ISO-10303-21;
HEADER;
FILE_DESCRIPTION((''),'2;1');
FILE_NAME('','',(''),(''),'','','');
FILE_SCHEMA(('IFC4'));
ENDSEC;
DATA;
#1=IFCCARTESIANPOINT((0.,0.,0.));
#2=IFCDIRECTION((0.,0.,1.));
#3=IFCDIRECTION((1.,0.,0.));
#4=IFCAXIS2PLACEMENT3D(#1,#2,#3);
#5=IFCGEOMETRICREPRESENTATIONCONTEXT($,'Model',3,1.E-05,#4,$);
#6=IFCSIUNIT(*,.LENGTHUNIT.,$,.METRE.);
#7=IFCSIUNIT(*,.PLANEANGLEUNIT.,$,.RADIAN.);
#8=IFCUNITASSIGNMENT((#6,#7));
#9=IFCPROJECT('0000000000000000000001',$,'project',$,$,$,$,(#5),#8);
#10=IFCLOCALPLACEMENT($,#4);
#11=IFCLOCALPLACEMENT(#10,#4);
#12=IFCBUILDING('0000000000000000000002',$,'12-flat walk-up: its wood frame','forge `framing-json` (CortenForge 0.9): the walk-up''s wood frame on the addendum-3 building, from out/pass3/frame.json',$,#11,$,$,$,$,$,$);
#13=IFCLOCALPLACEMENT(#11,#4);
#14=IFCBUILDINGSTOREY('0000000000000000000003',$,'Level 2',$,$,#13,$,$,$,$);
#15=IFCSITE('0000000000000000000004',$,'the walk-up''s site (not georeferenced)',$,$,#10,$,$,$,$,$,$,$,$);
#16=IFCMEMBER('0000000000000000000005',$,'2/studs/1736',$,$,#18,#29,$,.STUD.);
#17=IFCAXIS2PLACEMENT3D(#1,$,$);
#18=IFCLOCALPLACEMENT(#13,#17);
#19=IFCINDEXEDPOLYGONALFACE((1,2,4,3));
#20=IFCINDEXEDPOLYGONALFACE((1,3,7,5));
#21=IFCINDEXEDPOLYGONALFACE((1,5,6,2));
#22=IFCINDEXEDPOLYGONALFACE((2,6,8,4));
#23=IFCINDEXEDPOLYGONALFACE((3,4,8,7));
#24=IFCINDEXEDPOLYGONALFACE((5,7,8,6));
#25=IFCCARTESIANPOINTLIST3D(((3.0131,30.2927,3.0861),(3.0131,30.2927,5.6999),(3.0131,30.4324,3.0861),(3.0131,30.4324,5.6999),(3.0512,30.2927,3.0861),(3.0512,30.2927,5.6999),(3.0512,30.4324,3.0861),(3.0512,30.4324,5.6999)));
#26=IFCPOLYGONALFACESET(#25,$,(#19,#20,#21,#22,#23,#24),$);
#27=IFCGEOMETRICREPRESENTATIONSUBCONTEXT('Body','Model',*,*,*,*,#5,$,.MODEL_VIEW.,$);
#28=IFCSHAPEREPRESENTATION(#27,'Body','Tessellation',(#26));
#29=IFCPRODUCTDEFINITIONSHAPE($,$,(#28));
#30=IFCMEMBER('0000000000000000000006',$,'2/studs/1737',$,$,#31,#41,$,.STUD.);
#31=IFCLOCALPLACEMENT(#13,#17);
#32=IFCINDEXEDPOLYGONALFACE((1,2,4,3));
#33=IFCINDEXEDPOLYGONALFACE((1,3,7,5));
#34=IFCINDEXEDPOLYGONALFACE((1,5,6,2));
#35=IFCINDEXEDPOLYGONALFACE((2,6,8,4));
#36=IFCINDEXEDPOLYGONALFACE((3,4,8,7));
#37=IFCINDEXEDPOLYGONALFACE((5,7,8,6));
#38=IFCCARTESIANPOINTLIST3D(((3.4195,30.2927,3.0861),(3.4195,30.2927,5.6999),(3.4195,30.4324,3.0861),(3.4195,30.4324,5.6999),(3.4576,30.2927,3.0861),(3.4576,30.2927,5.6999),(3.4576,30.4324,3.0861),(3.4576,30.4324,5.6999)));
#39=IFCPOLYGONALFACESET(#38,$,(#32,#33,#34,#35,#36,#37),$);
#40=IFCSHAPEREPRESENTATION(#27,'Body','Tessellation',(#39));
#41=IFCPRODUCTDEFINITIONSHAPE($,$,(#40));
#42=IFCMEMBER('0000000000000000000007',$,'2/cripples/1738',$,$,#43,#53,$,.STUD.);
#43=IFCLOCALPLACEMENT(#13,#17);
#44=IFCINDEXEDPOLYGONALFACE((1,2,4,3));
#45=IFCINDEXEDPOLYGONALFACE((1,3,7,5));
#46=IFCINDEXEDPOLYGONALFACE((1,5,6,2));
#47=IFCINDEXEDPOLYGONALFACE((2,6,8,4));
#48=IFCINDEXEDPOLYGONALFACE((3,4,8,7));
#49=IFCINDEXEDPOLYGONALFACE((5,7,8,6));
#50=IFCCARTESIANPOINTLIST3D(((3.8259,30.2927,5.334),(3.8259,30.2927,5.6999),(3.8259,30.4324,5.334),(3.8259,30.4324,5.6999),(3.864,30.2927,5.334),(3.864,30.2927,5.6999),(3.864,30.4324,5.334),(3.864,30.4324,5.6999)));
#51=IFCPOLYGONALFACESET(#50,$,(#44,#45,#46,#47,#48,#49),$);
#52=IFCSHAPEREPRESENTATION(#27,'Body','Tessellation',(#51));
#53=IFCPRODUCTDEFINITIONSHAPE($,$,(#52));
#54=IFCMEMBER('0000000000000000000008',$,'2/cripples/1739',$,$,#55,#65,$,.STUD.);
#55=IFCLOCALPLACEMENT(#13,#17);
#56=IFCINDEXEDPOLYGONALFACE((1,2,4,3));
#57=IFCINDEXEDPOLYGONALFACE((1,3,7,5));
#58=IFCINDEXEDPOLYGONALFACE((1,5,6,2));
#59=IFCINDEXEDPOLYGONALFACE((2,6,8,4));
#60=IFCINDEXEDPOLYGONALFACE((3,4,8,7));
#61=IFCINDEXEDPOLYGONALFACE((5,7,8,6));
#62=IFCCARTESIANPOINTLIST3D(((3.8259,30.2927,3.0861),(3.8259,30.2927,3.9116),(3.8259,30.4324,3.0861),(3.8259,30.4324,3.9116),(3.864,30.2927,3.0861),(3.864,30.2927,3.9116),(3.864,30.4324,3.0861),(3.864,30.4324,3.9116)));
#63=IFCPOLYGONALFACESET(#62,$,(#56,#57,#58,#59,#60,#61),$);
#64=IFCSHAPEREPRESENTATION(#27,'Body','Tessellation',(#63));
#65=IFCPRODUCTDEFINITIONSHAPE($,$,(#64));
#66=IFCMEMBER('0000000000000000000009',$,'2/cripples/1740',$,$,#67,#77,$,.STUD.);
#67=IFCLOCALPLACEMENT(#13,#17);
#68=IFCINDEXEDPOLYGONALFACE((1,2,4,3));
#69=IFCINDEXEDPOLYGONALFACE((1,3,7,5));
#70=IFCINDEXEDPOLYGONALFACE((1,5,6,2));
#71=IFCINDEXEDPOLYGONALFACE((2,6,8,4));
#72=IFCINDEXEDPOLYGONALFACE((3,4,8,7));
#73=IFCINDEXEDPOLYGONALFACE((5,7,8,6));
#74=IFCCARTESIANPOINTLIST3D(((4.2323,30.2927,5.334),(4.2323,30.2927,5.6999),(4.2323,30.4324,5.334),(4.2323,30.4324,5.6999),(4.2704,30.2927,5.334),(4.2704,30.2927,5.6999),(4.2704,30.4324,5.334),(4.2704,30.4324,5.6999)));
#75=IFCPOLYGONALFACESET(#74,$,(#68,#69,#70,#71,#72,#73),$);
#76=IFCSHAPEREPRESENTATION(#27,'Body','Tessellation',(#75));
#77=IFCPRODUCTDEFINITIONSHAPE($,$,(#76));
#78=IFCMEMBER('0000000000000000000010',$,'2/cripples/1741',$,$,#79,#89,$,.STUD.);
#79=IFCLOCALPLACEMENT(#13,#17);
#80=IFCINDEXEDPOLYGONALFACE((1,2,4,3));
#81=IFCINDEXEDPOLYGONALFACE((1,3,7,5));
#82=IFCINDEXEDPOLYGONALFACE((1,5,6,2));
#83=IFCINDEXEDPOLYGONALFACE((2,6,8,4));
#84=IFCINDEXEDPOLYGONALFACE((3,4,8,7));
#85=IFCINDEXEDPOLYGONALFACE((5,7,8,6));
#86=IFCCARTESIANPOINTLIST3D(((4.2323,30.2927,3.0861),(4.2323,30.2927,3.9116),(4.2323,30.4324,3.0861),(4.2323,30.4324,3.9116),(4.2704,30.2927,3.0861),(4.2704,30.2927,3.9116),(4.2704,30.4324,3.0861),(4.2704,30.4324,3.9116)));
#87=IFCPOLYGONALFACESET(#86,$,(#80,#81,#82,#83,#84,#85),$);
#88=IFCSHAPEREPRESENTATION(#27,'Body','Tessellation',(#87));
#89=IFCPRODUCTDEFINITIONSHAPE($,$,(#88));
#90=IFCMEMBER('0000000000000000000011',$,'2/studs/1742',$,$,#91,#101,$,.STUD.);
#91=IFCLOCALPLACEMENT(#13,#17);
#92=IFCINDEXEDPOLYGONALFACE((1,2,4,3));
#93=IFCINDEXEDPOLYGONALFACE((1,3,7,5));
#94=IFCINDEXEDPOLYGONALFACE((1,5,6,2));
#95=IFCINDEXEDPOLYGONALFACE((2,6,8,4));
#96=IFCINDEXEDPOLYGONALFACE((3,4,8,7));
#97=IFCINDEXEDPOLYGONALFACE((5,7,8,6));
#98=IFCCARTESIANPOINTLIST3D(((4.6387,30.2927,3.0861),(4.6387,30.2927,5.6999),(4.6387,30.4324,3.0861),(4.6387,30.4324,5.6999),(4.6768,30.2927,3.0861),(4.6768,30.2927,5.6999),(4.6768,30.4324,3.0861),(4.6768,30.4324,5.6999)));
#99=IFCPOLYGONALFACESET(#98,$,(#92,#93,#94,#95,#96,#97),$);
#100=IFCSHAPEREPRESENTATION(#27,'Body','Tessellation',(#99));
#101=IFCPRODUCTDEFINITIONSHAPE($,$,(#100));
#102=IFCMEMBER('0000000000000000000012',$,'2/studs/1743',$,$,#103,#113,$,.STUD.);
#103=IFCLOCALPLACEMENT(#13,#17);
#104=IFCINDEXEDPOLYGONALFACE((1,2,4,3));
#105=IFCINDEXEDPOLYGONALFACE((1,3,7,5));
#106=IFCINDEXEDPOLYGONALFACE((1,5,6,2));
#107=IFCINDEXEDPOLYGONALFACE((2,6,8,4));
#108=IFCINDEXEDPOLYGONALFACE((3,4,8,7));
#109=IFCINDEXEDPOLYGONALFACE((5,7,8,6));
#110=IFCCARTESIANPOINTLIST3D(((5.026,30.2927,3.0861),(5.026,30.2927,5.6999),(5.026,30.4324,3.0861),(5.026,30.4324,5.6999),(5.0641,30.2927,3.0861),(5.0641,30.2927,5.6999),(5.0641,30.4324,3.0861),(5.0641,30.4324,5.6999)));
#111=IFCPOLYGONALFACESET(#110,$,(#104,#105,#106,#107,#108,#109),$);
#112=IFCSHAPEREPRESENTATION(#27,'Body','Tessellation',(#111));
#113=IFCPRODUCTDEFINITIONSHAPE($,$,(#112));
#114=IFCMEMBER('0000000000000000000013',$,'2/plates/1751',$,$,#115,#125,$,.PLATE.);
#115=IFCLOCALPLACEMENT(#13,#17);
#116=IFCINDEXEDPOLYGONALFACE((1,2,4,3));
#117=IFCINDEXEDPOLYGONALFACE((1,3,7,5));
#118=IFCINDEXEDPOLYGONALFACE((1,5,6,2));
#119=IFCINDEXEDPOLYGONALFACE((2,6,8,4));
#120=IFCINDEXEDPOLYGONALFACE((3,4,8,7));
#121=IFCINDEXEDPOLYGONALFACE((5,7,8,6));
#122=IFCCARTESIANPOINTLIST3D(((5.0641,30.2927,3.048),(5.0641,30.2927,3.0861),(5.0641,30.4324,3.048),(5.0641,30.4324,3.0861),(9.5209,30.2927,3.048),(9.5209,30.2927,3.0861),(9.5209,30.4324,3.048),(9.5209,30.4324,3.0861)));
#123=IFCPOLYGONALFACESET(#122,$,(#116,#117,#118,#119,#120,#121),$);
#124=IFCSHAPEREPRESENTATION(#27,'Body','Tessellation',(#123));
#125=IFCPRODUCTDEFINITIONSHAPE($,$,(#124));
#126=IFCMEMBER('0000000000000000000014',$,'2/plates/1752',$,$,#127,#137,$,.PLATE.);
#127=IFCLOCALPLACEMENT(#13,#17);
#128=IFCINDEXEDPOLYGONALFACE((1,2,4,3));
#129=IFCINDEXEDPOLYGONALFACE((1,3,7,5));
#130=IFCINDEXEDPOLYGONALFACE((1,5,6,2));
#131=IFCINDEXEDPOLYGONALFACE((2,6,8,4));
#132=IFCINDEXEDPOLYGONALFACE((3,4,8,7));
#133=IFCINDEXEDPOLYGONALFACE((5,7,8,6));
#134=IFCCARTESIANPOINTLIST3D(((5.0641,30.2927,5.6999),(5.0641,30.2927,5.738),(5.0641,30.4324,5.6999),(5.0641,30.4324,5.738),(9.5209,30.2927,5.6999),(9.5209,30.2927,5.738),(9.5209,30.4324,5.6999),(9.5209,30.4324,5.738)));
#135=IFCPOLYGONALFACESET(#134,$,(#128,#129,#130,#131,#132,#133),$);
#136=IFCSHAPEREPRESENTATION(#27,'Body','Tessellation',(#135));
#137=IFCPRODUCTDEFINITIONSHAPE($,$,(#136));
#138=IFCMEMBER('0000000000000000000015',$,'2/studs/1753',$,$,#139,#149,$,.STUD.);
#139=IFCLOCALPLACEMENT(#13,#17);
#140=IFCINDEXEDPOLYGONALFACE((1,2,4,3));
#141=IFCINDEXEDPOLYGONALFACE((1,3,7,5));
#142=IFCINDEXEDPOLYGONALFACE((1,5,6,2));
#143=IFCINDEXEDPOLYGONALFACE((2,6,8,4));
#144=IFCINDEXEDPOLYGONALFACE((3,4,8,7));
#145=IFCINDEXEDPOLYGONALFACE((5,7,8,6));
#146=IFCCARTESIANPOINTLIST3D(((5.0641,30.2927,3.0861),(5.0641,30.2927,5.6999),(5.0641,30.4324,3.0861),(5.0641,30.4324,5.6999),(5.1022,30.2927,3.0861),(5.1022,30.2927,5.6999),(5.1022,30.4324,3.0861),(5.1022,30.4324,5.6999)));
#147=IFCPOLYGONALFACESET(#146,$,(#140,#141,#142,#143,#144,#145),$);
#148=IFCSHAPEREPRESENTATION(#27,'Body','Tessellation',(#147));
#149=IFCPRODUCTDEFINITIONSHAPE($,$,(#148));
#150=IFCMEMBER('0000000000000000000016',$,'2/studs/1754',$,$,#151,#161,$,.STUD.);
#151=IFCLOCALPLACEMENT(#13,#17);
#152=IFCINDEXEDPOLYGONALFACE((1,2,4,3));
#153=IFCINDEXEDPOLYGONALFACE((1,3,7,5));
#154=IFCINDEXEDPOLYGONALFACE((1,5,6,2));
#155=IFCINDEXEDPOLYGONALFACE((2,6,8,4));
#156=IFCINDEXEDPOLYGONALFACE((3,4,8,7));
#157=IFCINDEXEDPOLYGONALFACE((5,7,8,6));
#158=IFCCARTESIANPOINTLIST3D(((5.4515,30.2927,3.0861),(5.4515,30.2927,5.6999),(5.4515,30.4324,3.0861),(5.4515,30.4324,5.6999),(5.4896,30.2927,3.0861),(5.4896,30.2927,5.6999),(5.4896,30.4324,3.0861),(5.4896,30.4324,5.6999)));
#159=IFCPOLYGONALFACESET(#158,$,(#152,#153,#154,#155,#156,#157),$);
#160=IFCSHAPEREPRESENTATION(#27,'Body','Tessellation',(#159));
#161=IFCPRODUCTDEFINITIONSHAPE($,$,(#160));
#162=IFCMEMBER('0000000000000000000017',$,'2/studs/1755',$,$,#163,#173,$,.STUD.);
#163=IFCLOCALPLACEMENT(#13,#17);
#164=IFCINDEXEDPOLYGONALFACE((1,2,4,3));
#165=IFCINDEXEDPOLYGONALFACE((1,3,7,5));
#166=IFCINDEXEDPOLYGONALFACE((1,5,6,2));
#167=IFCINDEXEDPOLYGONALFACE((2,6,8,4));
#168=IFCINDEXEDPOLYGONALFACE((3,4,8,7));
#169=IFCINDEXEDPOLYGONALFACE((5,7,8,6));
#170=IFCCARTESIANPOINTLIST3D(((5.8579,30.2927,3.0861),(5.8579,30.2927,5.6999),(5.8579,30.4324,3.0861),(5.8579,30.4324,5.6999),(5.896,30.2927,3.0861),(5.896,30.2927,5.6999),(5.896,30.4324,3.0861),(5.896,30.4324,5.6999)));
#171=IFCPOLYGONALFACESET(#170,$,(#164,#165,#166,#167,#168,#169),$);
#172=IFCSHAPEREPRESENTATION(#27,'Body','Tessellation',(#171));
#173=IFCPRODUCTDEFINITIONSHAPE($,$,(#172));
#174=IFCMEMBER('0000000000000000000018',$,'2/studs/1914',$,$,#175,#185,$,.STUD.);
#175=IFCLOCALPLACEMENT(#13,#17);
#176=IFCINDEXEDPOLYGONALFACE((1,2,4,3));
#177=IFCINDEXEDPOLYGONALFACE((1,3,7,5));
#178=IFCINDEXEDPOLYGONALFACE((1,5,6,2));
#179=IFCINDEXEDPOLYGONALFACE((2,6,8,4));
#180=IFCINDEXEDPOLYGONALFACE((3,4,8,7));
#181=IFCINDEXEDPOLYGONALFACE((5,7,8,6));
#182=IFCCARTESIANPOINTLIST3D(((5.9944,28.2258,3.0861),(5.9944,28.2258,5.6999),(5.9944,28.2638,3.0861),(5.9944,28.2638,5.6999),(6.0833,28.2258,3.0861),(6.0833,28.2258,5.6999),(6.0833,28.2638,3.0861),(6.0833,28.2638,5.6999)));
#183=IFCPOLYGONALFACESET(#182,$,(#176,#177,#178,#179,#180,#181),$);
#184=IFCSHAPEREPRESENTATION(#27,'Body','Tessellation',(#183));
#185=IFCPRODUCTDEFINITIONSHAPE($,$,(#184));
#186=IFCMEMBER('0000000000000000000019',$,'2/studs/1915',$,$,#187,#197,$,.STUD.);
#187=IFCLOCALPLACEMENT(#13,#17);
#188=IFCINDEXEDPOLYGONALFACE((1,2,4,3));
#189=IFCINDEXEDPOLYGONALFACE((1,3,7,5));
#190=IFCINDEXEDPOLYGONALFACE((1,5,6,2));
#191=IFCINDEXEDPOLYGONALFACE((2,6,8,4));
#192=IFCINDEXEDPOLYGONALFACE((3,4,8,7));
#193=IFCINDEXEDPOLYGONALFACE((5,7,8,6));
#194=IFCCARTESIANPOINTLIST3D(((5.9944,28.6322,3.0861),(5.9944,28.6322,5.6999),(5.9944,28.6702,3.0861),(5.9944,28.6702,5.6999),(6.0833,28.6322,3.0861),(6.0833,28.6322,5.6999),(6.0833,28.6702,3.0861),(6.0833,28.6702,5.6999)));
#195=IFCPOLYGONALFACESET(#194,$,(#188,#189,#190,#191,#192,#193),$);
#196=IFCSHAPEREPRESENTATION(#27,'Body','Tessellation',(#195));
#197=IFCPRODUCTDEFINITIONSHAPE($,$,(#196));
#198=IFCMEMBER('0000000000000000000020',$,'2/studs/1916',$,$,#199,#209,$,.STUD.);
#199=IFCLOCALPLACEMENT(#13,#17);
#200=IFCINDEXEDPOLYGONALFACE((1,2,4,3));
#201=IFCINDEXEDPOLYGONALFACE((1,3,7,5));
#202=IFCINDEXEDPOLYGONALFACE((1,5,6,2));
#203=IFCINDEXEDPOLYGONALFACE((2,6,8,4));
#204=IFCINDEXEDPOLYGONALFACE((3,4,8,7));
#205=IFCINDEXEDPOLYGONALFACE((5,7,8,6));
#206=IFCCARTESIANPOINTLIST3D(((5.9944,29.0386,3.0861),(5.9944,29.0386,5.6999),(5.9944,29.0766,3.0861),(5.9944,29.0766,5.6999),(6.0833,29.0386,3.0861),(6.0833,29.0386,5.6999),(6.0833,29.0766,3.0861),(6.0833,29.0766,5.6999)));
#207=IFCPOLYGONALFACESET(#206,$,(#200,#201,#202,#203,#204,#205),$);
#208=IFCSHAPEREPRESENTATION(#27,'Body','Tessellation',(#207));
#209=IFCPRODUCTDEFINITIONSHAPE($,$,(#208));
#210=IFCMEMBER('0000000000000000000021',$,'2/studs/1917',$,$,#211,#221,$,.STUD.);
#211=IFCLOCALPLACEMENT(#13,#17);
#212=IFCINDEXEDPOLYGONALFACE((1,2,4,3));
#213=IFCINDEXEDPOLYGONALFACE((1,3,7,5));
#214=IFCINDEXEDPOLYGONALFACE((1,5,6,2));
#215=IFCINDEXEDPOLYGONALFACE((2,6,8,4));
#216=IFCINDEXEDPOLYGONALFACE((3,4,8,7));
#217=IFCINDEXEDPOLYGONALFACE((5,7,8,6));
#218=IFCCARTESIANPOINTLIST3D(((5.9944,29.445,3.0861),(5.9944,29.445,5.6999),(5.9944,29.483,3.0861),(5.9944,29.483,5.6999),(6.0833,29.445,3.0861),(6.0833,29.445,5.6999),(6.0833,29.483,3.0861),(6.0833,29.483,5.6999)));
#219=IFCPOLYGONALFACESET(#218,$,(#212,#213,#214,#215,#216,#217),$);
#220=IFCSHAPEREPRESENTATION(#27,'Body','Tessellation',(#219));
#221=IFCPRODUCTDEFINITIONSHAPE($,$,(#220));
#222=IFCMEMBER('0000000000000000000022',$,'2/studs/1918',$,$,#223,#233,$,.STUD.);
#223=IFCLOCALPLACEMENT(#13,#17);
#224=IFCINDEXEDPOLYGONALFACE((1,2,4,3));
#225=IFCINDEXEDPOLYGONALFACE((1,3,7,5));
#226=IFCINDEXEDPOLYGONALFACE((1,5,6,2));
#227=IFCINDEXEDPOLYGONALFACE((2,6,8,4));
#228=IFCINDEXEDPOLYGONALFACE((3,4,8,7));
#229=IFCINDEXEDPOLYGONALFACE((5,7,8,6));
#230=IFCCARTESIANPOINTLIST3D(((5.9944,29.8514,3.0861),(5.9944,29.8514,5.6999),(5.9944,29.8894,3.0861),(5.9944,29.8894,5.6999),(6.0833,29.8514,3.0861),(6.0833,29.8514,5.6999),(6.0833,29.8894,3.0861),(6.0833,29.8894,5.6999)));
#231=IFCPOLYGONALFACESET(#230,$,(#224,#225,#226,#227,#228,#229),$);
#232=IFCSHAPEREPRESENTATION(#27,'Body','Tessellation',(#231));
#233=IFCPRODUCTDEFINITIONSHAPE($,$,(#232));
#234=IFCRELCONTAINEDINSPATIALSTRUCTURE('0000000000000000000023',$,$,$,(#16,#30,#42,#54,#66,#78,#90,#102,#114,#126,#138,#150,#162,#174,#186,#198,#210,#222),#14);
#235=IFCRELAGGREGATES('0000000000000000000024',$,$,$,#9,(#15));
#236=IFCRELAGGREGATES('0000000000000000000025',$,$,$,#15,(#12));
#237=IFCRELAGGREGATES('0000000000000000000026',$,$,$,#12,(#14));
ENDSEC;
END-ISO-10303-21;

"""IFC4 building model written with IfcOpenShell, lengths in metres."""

from ifc_helpers import new_model, si_unit, frame, frame_2d, origin, origin_with_axes, place, context, subcontext, project, spatial, rectangle, extrude, element, save


model = new_model("IFC4")

# Units and contexts
model_context = context("Model", 3, precision=1e-05, world=origin_with_axes())
body_context = subcontext(model_context, "Body", "Model", "MODEL_VIEW")
ifc_project = project(units=[si_unit("LENGTHUNIT", "METRE"), si_unit("PLANEANGLEUNIT", "RADIAN")], contexts=[model_context])

# Site, building, storey
site_placement = place(None, origin_with_axes())
site = spatial("IfcSite", under=ifc_project, at=site_placement, Name="the walk-up's site (not georeferenced)")
building_placement = place(site_placement, origin_with_axes())
building = spatial("IfcBuilding", under=site, at=building_placement, Name="12-flat walk-up: its wood frame", Description="forge `framing-json` (CortenForge 0.9): the walk-up's wood frame on the addendum-3 building, from out/pass3/frame.json")
storey_placement = place(building_placement, origin_with_axes())
storey = spatial("IfcBuildingStorey", under=building, at=storey_placement, Name="Level 2")

# Members
for number, where, z_axis, x_axis, name in (
    (1, (3.0131, 30.2927, 3.0861), (0.0, 0.0, 1.0), (1.0, 0.0, 0.0), "2/studs/1736"),
    (2, (3.4195, 30.2927, 3.0861), (0.0, 0.0, 1.0), (1.0, 0.0, 0.0), "2/studs/1737"),
):
    element("IfcMember", number, at=place(storey_placement, frame(where, z_axis=z_axis, x_axis=x_axis)), inside=storey, Name=name, PredefinedType="STUD", context=body_context, shape_type="SweptSolid", body=[
        extrude(rectangle(XDim=0.0381, YDim=0.1397, at=frame_2d((0.0191, 0.0699))), origin(), (0.0, 0.0, 1.0), 2.6138),
    ])
member_1_placement = place(storey_placement, frame((3.8259, 30.2927, 5.334), z_axis=(0.0, 0.0, 1.0), x_axis=(1.0, 0.0, 0.0)))
element("IfcMember", 3, at=member_1_placement, inside=storey, Name="2/cripples/1738", PredefinedType="STUD", context=body_context, shape_type="SweptSolid", body=[
    extrude(rectangle(XDim=0.0381, YDim=0.1397, at=frame_2d((0.0191, 0.0699))), origin(), (0.0, 0.0, 1.0), 0.3659),
])
member_2_placement = place(storey_placement, frame((3.8259, 30.2927, 3.0861), z_axis=(0.0, 0.0, 1.0), x_axis=(1.0, 0.0, 0.0)))
element("IfcMember", 4, at=member_2_placement, inside=storey, Name="2/cripples/1739", PredefinedType="STUD", context=body_context, shape_type="SweptSolid", body=[
    extrude(rectangle(XDim=0.0381, YDim=0.1397, at=frame_2d((0.0191, 0.0699))), origin(), (0.0, 0.0, 1.0), 0.8255),
])
member_3_placement = place(storey_placement, frame((4.2323, 30.2927, 5.334), z_axis=(0.0, 0.0, 1.0), x_axis=(1.0, 0.0, 0.0)))
element("IfcMember", 5, at=member_3_placement, inside=storey, Name="2/cripples/1740", PredefinedType="STUD", context=body_context, shape_type="SweptSolid", body=[
    extrude(rectangle(XDim=0.0381, YDim=0.1397, at=frame_2d((0.0191, 0.0699))), origin(), (0.0, 0.0, 1.0), 0.3659),
])
member_4_placement = place(storey_placement, frame((4.2323, 30.2927, 3.0861), z_axis=(0.0, 0.0, 1.0), x_axis=(1.0, 0.0, 0.0)))
element("IfcMember", 6, at=member_4_placement, inside=storey, Name="2/cripples/1741", PredefinedType="STUD", context=body_context, shape_type="SweptSolid", body=[
    extrude(rectangle(XDim=0.0381, YDim=0.1397, at=frame_2d((0.0191, 0.0699))), origin(), (0.0, 0.0, 1.0), 0.8255),
])
for number, where, z_axis, x_axis, name in (
    (7, (4.6387, 30.2927, 3.0861), (0.0, 0.0, 1.0), (1.0, 0.0, 0.0), "2/studs/1742"),
    (8, (5.026, 30.2927, 3.0861), (0.0, 0.0, 1.0), (1.0, 0.0, 0.0), "2/studs/1743"),
):
    element("IfcMember", number, at=place(storey_placement, frame(where, z_axis=z_axis, x_axis=x_axis)), inside=storey, Name=name, PredefinedType="STUD", context=body_context, shape_type="SweptSolid", body=[
        extrude(rectangle(XDim=0.0381, YDim=0.1397, at=frame_2d((0.0191, 0.0699))), origin(), (0.0, 0.0, 1.0), 2.6138),
    ])
for number, where, z_axis, x_axis, name in (
    (9, (5.0641, 30.2927, 3.048), (0.0, 0.0, 1.0), (1.0, 0.0, 0.0), "2/plates/1751"),
    (10, (5.0641, 30.2927, 5.6999), (0.0, 0.0, 1.0), (1.0, 0.0, 0.0), "2/plates/1752"),
):
    element("IfcMember", number, at=place(storey_placement, frame(where, z_axis=z_axis, x_axis=x_axis)), inside=storey, Name=name, PredefinedType="PLATE", context=body_context, shape_type="SweptSolid", body=[
        extrude(rectangle(XDim=4.4568, YDim=0.1397, at=frame_2d((2.2284, 0.0699))), origin(), (0.0, 0.0, 1.0), 0.0381),
    ])
for number, where, z_axis, x_axis, name in (
    (11, (5.0641, 30.2927, 3.0861), (0.0, 0.0, 1.0), (1.0, 0.0, 0.0), "2/studs/1753"),
    (12, (5.4515, 30.2927, 3.0861), (0.0, 0.0, 1.0), (1.0, 0.0, 0.0), "2/studs/1754"),
    (13, (5.8579, 30.2927, 3.0861), (0.0, 0.0, 1.0), (1.0, 0.0, 0.0), "2/studs/1755"),
):
    element("IfcMember", number, at=place(storey_placement, frame(where, z_axis=z_axis, x_axis=x_axis)), inside=storey, Name=name, PredefinedType="STUD", context=body_context, shape_type="SweptSolid", body=[
        extrude(rectangle(XDim=0.0381, YDim=0.1397, at=frame_2d((0.0191, 0.0699))), origin(), (0.0, 0.0, 1.0), 2.6138),
    ])
for number, where, z_axis, x_axis, name in (
    (14, (5.9944, 28.2258, 3.0861), (0.0, 0.0, 1.0), (1.0, 0.0, 0.0), "2/studs/1914"),
    (15, (5.9944, 28.6321, 3.0861), (0.0, 0.0, 1.0), (1.0, 0.0, 0.0), "2/studs/1915"),
    (16, (5.9944, 29.0386, 3.0861), (0.0, 0.0, 1.0), (1.0, 0.0, 0.0), "2/studs/1916"),
    (17, (5.9944, 29.4449, 3.0861), (0.0, 0.0, 1.0), (1.0, 0.0, 0.0), "2/studs/1917"),
    (18, (5.9944, 29.8514, 3.0861), (0.0, 0.0, 1.0), (1.0, 0.0, 0.0), "2/studs/1918"),
):
    element("IfcMember", number, at=place(storey_placement, frame(where, z_axis=z_axis, x_axis=x_axis)), inside=storey, Name=name, PredefinedType="STUD", context=body_context, shape_type="SweptSolid", body=[
        extrude(rectangle(XDim=0.0889, YDim=0.0381, at=frame_2d((0.0445, 0.0191))), origin(), (0.0, 0.0, 1.0), 2.6138),
    ])

save(model, "model.ifc")
